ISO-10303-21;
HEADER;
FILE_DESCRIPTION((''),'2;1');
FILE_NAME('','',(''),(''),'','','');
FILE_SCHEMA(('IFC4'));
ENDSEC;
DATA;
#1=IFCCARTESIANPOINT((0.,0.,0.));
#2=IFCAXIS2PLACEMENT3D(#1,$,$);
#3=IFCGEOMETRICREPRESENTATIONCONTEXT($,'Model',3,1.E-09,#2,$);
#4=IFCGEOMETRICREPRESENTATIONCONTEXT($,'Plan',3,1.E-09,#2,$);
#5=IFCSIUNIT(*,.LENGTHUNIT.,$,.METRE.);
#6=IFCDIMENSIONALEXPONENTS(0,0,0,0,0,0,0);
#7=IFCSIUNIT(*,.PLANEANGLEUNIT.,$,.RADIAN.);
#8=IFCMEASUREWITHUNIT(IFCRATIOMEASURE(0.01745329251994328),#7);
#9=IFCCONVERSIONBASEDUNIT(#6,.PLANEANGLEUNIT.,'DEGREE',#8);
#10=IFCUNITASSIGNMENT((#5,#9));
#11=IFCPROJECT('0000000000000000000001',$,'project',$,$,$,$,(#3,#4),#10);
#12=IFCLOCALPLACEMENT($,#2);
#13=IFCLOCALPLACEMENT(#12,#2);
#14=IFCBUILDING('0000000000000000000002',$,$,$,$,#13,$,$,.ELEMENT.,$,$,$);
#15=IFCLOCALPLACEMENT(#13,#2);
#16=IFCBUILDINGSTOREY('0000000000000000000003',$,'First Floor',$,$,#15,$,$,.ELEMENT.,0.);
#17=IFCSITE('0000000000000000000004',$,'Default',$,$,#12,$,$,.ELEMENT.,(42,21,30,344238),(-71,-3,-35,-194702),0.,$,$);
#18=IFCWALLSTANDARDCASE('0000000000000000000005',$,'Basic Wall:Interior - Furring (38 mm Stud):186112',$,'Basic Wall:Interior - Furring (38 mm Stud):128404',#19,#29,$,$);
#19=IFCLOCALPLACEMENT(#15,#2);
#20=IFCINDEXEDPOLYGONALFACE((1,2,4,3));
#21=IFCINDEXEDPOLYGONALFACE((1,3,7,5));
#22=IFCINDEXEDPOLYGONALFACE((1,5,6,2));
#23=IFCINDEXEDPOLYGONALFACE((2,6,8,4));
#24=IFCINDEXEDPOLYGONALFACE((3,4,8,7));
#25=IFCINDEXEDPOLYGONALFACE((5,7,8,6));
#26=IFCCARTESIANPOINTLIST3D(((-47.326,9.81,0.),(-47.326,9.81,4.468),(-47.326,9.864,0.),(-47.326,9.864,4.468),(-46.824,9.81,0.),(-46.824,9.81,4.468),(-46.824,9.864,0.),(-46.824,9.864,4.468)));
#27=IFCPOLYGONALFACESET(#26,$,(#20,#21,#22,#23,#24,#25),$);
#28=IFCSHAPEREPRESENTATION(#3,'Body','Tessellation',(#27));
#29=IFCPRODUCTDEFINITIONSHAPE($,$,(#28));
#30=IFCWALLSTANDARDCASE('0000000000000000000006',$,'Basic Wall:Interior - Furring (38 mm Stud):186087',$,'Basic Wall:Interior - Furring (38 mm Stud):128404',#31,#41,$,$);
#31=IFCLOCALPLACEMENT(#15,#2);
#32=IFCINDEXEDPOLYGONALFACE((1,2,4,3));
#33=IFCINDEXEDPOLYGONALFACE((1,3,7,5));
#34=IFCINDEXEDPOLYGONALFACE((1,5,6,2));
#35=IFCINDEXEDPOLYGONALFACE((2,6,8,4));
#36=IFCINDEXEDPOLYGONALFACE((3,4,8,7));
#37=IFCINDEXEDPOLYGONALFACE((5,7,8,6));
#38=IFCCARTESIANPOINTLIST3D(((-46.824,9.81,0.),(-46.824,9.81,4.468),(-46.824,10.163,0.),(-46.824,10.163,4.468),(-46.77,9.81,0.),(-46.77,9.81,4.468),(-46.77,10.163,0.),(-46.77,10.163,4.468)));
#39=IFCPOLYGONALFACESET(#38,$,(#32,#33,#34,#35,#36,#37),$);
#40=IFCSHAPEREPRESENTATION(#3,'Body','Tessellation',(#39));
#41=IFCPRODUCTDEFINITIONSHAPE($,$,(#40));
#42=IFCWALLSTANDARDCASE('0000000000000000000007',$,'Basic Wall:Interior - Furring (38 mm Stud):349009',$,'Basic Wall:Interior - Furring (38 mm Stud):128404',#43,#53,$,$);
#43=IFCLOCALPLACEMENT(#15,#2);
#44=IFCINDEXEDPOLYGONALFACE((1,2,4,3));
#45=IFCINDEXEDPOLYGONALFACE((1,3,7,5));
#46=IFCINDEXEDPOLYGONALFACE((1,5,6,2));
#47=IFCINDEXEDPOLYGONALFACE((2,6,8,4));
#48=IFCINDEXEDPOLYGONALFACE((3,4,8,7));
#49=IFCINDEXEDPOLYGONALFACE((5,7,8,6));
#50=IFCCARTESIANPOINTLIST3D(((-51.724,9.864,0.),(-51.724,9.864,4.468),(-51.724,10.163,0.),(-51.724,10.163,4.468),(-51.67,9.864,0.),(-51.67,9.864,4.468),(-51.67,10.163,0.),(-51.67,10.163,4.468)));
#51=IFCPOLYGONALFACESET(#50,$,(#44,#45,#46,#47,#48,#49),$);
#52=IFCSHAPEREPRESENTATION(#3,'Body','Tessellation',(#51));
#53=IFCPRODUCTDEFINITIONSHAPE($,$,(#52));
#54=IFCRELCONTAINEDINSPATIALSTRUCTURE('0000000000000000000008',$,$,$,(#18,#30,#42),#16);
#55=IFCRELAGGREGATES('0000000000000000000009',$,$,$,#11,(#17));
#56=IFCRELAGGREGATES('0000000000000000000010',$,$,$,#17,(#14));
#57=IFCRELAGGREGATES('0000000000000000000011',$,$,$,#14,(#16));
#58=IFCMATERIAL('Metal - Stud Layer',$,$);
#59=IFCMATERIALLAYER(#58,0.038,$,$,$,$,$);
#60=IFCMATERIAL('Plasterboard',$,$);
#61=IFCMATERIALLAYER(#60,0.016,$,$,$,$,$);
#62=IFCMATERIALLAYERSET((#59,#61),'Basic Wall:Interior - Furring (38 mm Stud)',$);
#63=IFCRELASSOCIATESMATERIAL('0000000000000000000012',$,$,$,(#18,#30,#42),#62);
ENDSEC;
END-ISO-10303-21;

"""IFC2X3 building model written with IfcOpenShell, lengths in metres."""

from ifc_helpers import new_model, entity, si_unit, converted_unit, frame, frame_2d, origin, place, context, project, spatial, rectangle, extrude, material, layer, layer_set, layer_usage, element, save


model = new_model("IFC2X3")

# Units and contexts
model_context = context("Model", 3, precision=1e-09, world=origin())
plan_context = context("Plan", 3, precision=1e-09, world=origin())
ifc_project = project(units=[si_unit("LENGTHUNIT", "METRE"), converted_unit("PLANEANGLEUNIT", "DEGREE", entity("IfcRatioMeasure", 0.01745329251994328), si_unit("PLANEANGLEUNIT", "RADIAN"), dimensions=[0, 0, 0, 0, 0, 0, 0])], contexts=[model_context, plan_context])

# Site, building, storey
site_placement = place(None, origin())
site = spatial("IfcSite", under=ifc_project, at=site_placement, Name="Default", CompositionType="ELEMENT", RefLatitude=(42, 21, 30, 344238), RefLongitude=(-71, -3, -35, -194702), RefElevation=0.0)
building_placement = place(site_placement, origin())
building = spatial("IfcBuilding", under=site, at=building_placement, CompositionType="ELEMENT")
storey_placement = place(building_placement, origin())
storey = spatial("IfcBuildingStorey", under=building, at=storey_placement, Name="First Floor", CompositionType="ELEMENT", Elevation=0.0)

# Shared definitions
ifc_material_1 = material(Name="Metal - Stud Layer")
ifc_material_2 = material(Name="Plasterboard")

# Walls
ifc_layer_1 = layer(ifc_material_1, 0.038)
ifc_layer_2 = layer(ifc_material_2, 0.016)
ifc_layer_set_1 = layer_set([ifc_layer_1, ifc_layer_2], Name="Basic Wall:Interior - Furring (38 mm Stud)")
ifc_layer_usage_1 = layer_usage(ifc_layer_set_1, "AXIS2", "POSITIVE", -0.027)
wall_1_placement = place(storey_placement, frame((-46.824, 9.837, 0.0), z_axis=(0.0, 0.0, 1.0), x_axis=(-1.0, 0.0, 0.0)))
element("IfcWallStandardCase", 1, at=wall_1_placement, inside=storey, material=ifc_layer_usage_1, Name="Basic Wall:Interior - Furring (38 mm Stud):186112", ObjectType="Basic Wall:Interior - Furring (38 mm Stud):128404", context=model_context, shape_type="SweptSolid", body=[
    extrude(rectangle(XDim=0.502, YDim=0.054, at=frame_2d((0.251, 0.0), x_axis=(-1.0, 0.0))), origin(), (0.0, 0.0, 1.0), 4.468),
])
wall_2_placement = place(storey_placement, frame((-46.797, 10.163, 0.0), z_axis=(0.0, 0.0, 1.0), x_axis=(0.0, -1.0, 0.0)))
element("IfcWallStandardCase", 2, at=wall_2_placement, inside=storey, material=ifc_layer_usage_1, Name="Basic Wall:Interior - Furring (38 mm Stud):186087", ObjectType="Basic Wall:Interior - Furring (38 mm Stud):128404", context=model_context, shape_type="SweptSolid", body=[
    extrude(rectangle(XDim=0.353, YDim=0.054, at=frame_2d((0.1765, 0.0), x_axis=(-1.0, 0.0))), origin(), (0.0, 0.0, 1.0), 4.468),
])
ifc_layer_usage_2 = layer_usage(ifc_layer_set_1, "AXIS2", "NEGATIVE", 0.027)
wall_3_placement = place(storey_placement, frame((-51.697, 9.864, 0.0), z_axis=(0.0, 0.0, 1.0), x_axis=(0.0, 1.0, 0.0)))
element("IfcWallStandardCase", 3, at=wall_3_placement, inside=storey, material=ifc_layer_usage_2, Name="Basic Wall:Interior - Furring (38 mm Stud):349009", ObjectType="Basic Wall:Interior - Furring (38 mm Stud):128404", context=model_context, shape_type="SweptSolid", body=[
    extrude(rectangle(XDim=0.299, YDim=0.054, at=frame_2d((0.1495, 0.0), x_axis=(-1.0, 0.0))), origin(), (0.0, 0.0, 1.0), 4.468),
])

save(model, "model.ifc")
